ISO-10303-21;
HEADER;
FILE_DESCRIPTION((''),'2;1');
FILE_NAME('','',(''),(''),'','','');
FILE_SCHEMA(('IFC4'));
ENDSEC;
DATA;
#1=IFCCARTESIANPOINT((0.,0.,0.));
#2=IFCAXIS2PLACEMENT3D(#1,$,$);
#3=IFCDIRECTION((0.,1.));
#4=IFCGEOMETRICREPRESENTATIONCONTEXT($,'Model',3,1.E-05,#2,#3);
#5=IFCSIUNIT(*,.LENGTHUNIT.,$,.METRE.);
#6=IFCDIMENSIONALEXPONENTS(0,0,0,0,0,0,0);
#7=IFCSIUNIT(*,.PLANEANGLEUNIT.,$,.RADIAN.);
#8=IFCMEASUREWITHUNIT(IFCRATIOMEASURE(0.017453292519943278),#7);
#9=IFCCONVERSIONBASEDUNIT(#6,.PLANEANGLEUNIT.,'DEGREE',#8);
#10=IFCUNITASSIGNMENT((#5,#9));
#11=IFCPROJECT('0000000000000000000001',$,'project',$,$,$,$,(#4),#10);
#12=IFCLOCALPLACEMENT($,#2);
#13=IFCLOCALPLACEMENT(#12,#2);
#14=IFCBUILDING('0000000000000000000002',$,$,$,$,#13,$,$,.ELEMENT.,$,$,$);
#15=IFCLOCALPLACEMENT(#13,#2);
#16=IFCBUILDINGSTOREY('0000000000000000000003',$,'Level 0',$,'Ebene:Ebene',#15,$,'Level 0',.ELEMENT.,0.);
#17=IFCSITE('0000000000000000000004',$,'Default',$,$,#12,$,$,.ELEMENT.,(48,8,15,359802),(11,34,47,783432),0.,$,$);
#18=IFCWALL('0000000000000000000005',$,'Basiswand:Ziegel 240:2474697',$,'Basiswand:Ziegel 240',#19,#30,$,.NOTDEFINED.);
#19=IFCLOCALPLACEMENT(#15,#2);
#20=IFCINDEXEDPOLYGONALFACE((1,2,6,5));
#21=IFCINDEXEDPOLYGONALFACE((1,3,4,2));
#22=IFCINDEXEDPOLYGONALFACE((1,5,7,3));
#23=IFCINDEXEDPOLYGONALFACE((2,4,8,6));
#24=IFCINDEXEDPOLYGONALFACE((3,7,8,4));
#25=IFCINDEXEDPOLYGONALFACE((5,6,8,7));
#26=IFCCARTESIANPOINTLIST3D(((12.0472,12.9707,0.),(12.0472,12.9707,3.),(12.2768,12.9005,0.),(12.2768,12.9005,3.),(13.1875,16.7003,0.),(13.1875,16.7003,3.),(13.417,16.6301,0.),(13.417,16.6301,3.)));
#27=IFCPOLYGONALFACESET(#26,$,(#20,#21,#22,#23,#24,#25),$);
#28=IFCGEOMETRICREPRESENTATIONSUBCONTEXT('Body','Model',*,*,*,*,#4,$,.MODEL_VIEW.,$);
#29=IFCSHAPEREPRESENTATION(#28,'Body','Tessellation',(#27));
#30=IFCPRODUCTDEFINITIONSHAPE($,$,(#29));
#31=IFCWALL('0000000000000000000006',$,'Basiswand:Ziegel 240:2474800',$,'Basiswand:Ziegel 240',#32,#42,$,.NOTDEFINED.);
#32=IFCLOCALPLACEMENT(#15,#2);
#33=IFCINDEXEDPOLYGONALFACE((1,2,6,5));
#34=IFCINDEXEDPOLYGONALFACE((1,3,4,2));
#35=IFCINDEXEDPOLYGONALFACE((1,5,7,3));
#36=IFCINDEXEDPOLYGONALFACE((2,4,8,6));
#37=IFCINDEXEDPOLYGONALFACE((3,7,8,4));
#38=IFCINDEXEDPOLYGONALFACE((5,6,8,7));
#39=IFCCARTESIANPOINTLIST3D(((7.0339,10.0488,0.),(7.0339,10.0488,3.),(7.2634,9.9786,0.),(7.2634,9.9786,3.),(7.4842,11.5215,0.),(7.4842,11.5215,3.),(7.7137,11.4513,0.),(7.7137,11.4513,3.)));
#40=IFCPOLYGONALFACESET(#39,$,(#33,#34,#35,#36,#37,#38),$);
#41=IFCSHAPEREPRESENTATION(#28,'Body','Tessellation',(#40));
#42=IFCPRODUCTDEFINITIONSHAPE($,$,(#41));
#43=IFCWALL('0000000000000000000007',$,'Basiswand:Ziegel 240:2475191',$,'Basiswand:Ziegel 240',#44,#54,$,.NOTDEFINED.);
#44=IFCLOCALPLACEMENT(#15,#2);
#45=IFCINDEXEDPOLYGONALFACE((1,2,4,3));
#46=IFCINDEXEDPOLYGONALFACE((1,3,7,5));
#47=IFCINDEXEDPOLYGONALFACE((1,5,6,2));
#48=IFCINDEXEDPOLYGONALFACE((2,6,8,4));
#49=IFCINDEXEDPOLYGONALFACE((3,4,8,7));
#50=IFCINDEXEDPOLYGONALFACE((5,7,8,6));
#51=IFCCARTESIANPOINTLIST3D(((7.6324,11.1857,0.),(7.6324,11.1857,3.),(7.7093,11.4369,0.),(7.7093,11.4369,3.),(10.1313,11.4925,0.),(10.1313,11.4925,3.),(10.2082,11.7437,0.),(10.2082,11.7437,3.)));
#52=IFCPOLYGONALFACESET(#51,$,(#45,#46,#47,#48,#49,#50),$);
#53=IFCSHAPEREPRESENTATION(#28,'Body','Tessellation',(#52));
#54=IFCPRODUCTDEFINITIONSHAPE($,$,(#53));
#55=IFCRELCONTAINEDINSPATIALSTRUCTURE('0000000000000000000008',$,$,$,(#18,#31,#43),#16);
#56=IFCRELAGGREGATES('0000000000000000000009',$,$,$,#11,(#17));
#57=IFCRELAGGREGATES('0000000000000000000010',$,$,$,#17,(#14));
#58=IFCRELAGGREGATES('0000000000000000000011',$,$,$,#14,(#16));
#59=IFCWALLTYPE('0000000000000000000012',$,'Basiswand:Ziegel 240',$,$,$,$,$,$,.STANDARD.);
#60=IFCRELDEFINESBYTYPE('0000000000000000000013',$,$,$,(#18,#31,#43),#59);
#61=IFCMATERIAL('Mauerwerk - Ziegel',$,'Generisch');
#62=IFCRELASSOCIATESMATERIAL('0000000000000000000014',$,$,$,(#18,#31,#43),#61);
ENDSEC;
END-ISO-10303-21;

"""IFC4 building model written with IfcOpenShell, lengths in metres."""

from ifc_helpers import new_model, entity, si_unit, converted_unit, direction, frame, origin, place, context, subcontext, project, spatial, indexed_curve, outline, extrude, material, type_object, element, save


model = new_model("IFC4")

# Units and contexts
model_context = context("Model", 3, precision=1e-05, world=origin(), true_north=direction((0.0, 1.0)))
body_context = subcontext(model_context, "Body", "Model", "MODEL_VIEW")
ifc_project = project(units=[si_unit("LENGTHUNIT", "METRE"), converted_unit("PLANEANGLEUNIT", "DEGREE", entity("IfcRatioMeasure", 0.017453292519943278), si_unit("PLANEANGLEUNIT", "RADIAN"), dimensions=[0, 0, 0, 0, 0, 0, 0])], contexts=[model_context])

# Site, building, storey
site_placement = place(None, origin())
site = spatial("IfcSite", under=ifc_project, at=site_placement, Name="Default", CompositionType="ELEMENT", RefLatitude=(48, 8, 15, 359802), RefLongitude=(11, 34, 47, 783432), RefElevation=0.0)
building_placement = place(site_placement, origin())
building = spatial("IfcBuilding", under=site, at=building_placement, CompositionType="ELEMENT")
storey_placement = place(building_placement, origin())
storey = spatial("IfcBuildingStorey", under=building, at=storey_placement, Name="Level 0", ObjectType="Ebene:Ebene", LongName="Level 0", CompositionType="ELEMENT", Elevation=0.0)

# Shared definitions
ifc_material_1 = material(Name="Mauerwerk - Ziegel", Category="Generisch")

# Walls
wall_type_1 = type_object("IfcWallType", Name="Basiswand:Ziegel 240", PredefinedType="STANDARD")
wall_1_placement = place(storey_placement, frame((12.162, 12.9356, 0.0), z_axis=(0.0, 0.0, 1.0), x_axis=(0.292372, 0.956305, 0.0)))
element("IfcWall", 1, at=wall_1_placement, inside=storey, type_object=wall_type_1, material=ifc_material_1, Name="Basiswand:Ziegel 240:2474697", ObjectType="Basiswand:Ziegel 240", PredefinedType="NOTDEFINED", context=body_context, shape_type="SweptSolid", body=[
    extrude(outline(indexed_curve([(3.9, 0.12), (0.0, 0.12), (0.0, -0.12), (3.9, -0.12), (3.9, 0.12)], self_intersect=False)), origin(), (0.0, 0.0, 1.0), 3.0),
])
wall_2_placement = place(storey_placement, frame((7.1487, 10.0137, 0.0), z_axis=(0.0, 0.0, 1.0), x_axis=(0.292372, 0.956305, 0.0)))
element("IfcWall", 2, at=wall_2_placement, inside=storey, type_object=wall_type_1, material=ifc_material_1, Name="Basiswand:Ziegel 240:2474800", ObjectType="Basiswand:Ziegel 240", PredefinedType="NOTDEFINED", context=body_context, shape_type="SweptSolid", body=[
    extrude(outline(indexed_curve([(1.54, 0.12), (0.0, 0.12), (0.0, -0.12), (1.54, -0.12), (1.54, 0.12)], self_intersect=False)), origin(), (0.0, 0.0, 1.0), 3.0),
])
wall_3_placement = place(storey_placement, frame((10.2228, 11.6246, 0.0), z_axis=(0.0, 0.0, 1.0), x_axis=(-0.992546, -0.121869, 0.0)))
element("IfcWall", 3, at=wall_3_placement, inside=storey, type_object=wall_type_1, material=ifc_material_1, Name="Basiswand:Ziegel 240:2475191", ObjectType="Basiswand:Ziegel 240", PredefinedType="NOTDEFINED", context=body_context, shape_type="SweptSolid", body=[
    extrude(outline(indexed_curve([(2.5177, -0.12), (2.6245, 0.12), (0.1069, 0.12), (0.0, -0.12), (2.5177, -0.12)], self_intersect=False)), origin(), (0.0, 0.0, 1.0), 3.0),
])

save(model, "model.ifc")
